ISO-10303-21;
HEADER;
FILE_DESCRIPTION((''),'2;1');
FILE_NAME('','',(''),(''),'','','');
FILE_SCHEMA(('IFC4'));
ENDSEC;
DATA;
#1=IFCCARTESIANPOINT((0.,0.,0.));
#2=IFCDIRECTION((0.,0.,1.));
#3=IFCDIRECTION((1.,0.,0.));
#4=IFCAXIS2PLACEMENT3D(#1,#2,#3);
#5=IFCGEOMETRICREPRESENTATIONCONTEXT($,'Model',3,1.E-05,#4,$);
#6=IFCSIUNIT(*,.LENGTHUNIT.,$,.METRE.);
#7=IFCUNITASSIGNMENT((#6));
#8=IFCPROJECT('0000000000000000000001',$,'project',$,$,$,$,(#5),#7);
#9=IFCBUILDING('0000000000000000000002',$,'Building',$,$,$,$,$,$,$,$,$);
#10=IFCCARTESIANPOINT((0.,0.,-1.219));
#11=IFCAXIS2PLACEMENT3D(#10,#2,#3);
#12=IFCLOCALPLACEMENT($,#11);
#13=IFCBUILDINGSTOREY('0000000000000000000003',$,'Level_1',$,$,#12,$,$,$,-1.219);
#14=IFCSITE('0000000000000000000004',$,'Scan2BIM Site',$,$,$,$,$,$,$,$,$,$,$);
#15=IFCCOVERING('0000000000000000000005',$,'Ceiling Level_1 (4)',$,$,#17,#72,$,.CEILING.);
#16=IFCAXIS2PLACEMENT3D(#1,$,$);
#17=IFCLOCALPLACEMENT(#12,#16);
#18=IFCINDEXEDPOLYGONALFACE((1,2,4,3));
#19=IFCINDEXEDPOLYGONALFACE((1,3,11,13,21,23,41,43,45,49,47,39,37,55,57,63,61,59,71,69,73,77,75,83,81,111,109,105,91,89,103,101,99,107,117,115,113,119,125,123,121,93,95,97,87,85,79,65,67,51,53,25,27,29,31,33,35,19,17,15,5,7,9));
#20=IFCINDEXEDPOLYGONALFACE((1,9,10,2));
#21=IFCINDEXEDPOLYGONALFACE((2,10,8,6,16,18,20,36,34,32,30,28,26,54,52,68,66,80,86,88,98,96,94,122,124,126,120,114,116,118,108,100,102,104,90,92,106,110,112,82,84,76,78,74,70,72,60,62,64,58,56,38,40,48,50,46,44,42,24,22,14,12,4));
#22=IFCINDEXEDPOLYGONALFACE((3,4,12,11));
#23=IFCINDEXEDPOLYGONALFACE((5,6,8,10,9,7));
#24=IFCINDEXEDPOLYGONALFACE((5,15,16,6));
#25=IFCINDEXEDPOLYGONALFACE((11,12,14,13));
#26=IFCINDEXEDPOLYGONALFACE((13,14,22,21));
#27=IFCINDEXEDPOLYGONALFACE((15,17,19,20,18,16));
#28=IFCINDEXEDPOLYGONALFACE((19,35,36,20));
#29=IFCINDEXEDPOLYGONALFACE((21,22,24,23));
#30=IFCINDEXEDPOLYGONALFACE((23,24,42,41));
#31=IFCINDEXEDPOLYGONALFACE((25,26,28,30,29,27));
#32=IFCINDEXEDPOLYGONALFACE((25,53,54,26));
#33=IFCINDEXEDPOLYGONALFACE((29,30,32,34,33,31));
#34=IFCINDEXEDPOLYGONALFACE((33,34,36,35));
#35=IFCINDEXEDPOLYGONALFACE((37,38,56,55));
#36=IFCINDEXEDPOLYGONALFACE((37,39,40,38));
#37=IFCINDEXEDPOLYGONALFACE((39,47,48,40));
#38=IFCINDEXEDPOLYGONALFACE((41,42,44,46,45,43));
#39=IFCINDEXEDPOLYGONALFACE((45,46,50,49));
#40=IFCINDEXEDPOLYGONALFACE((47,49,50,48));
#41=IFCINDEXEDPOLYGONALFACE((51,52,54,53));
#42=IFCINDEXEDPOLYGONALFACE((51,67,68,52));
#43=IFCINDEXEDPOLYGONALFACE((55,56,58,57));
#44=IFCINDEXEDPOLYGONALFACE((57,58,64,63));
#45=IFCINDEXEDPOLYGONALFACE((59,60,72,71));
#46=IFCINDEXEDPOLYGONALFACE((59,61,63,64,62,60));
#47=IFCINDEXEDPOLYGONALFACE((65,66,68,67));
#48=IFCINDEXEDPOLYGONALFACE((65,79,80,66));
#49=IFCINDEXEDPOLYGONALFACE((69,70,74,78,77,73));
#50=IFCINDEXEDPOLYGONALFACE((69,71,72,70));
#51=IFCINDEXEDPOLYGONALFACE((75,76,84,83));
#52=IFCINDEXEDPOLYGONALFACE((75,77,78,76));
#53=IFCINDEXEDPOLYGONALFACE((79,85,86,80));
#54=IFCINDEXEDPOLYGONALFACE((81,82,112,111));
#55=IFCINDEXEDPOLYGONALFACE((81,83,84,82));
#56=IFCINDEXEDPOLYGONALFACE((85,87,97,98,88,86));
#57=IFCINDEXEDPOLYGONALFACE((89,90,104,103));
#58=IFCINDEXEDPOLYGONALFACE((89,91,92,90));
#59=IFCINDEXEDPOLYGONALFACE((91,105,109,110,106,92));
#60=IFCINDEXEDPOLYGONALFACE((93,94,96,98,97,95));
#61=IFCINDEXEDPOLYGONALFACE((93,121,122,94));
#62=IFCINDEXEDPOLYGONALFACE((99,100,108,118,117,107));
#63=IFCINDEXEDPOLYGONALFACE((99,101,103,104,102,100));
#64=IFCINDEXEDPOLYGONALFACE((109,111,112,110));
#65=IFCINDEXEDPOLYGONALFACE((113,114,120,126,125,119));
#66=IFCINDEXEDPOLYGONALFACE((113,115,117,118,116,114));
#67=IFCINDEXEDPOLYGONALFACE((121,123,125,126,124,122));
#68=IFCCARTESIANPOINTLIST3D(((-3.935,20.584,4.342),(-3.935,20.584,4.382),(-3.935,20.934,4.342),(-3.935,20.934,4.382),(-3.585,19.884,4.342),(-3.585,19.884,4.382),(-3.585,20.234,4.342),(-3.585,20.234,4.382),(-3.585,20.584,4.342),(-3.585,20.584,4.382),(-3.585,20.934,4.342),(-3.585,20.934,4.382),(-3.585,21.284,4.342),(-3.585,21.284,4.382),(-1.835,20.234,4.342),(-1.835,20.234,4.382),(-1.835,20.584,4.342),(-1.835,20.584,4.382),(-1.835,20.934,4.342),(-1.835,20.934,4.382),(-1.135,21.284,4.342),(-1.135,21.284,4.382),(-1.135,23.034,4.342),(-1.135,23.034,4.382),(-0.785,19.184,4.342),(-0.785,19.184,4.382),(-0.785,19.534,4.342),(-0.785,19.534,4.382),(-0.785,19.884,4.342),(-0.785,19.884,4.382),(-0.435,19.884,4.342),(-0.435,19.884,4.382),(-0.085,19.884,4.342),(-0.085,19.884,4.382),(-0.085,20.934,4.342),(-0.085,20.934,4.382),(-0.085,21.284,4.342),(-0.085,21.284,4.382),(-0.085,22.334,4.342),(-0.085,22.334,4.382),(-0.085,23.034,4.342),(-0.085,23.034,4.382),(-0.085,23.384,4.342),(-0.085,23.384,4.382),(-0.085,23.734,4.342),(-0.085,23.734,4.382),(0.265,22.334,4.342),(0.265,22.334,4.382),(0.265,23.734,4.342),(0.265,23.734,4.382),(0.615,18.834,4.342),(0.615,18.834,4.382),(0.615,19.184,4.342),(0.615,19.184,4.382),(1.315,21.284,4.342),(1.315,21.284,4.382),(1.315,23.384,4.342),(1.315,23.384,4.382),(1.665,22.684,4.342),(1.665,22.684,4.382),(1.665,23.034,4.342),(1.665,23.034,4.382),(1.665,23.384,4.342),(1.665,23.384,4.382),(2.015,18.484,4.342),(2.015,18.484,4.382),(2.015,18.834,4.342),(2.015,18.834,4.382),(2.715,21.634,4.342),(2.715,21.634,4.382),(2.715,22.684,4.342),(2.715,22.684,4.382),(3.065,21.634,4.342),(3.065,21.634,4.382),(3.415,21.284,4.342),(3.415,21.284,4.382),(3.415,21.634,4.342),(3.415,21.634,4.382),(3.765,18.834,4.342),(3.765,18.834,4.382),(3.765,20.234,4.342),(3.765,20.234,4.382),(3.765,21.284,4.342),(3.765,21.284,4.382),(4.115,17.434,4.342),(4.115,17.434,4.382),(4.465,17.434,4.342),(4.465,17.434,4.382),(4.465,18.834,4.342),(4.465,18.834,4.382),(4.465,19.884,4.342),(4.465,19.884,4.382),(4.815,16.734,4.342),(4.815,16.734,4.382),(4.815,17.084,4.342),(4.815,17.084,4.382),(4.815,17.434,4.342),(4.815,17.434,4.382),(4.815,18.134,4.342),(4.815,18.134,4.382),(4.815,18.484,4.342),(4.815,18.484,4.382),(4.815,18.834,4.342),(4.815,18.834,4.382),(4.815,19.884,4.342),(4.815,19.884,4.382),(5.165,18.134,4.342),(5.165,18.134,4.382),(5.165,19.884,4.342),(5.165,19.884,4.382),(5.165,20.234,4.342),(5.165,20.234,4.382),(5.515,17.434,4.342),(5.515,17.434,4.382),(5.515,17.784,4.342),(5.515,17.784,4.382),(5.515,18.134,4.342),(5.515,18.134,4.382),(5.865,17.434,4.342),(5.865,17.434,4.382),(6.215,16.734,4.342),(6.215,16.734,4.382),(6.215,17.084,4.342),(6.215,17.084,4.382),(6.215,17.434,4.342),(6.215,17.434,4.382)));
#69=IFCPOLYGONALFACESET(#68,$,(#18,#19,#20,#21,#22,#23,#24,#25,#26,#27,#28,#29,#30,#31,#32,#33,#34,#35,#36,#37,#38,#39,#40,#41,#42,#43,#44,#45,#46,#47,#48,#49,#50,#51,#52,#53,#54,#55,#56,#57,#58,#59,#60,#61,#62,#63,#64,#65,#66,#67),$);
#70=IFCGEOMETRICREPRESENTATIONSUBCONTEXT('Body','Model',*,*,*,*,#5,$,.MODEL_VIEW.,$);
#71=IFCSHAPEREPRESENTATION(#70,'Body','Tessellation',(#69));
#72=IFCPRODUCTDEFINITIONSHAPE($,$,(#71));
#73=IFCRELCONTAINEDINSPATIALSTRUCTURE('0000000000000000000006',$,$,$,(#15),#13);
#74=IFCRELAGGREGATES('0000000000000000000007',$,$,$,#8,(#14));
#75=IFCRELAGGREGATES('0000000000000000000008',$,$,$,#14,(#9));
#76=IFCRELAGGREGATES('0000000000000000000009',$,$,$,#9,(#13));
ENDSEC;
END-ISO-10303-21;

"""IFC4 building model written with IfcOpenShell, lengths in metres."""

from ifc_helpers import new_model, si_unit, frame, origin, origin_with_axes, place, context, subcontext, project, spatial, polyline, outline, extrude, element, save


model = new_model("IFC4")

# Units and contexts
model_context = context("Model", 3, precision=1e-05, world=origin_with_axes())
body_context = subcontext(model_context, "Body", "Model", "MODEL_VIEW")
ifc_project = project(units=[si_unit("LENGTHUNIT", "METRE")], contexts=[model_context])

# Site, building, storey
site = spatial("IfcSite", under=ifc_project, Name="Scan2BIM Site")
building = spatial("IfcBuilding", under=site, Name="Building")
storey_placement = place(None, frame((0.0, 0.0, -1.219), z_axis=(0.0, 0.0, 1.0), x_axis=(1.0, 0.0, 0.0)))
storey = spatial("IfcBuildingStorey", under=building, at=storey_placement, Name="Level_1", Elevation=-1.219)

# Covering
covering_placement = place(storey_placement, frame((0.0, 0.0, 4.342), z_axis=(0.0, 0.0, 1.0), x_axis=(1.0, 0.0, 0.0)))
element("IfcCovering", 1, at=covering_placement, inside=storey, Name="Ceiling Level_1 (4)", PredefinedType="CEILING", context=body_context, shape_type="SweptSolid", body=[
    extrude(outline(polyline([(4.815, 16.734), (6.215, 16.734), (6.215, 17.084), (6.215, 17.434), (5.865, 17.434), (5.515, 17.434), (5.515, 17.784), (5.515, 18.134), (5.165, 18.134), (4.815, 18.134), (4.815, 18.484), (4.815, 18.834), (4.465, 18.834), (4.465, 19.884), (4.815, 19.884), (5.165, 19.884), (5.165, 20.234), (3.765, 20.234), (3.765, 21.284), (3.415, 21.284), (3.415, 21.634), (3.065, 21.634), (2.715, 21.634), (2.715, 22.684), (1.665, 22.684), (1.665, 23.034), (1.665, 23.384), (1.315, 23.384), (1.315, 21.284), (-0.085, 21.284), (-0.085, 22.334), (0.265, 22.334), (0.265, 23.734), (-0.085, 23.734), (-0.085, 23.384), (-0.085, 23.034), (-1.135, 23.034), (-1.135, 21.284), (-3.585, 21.284), (-3.585, 20.934), (-3.935, 20.934), (-3.935, 20.584), (-3.585, 20.584), (-3.585, 20.234), (-3.585, 19.884), (-1.835, 20.234), (-1.835, 20.584), (-1.835, 20.934), (-0.085, 20.934), (-0.085, 19.884), (-0.435, 19.884), (-0.785, 19.884), (-0.785, 19.534), (-0.785, 19.184), (0.615, 19.184), (0.615, 18.834), (2.015, 18.834), (2.015, 18.484), (3.765, 18.834), (4.115, 17.434), (4.465, 17.434), (4.815, 17.434), (4.815, 17.084), (4.815, 16.734)])), origin(), (0.0, 0.0, 1.0), 0.04),
])

save(model, "model.ifc")
